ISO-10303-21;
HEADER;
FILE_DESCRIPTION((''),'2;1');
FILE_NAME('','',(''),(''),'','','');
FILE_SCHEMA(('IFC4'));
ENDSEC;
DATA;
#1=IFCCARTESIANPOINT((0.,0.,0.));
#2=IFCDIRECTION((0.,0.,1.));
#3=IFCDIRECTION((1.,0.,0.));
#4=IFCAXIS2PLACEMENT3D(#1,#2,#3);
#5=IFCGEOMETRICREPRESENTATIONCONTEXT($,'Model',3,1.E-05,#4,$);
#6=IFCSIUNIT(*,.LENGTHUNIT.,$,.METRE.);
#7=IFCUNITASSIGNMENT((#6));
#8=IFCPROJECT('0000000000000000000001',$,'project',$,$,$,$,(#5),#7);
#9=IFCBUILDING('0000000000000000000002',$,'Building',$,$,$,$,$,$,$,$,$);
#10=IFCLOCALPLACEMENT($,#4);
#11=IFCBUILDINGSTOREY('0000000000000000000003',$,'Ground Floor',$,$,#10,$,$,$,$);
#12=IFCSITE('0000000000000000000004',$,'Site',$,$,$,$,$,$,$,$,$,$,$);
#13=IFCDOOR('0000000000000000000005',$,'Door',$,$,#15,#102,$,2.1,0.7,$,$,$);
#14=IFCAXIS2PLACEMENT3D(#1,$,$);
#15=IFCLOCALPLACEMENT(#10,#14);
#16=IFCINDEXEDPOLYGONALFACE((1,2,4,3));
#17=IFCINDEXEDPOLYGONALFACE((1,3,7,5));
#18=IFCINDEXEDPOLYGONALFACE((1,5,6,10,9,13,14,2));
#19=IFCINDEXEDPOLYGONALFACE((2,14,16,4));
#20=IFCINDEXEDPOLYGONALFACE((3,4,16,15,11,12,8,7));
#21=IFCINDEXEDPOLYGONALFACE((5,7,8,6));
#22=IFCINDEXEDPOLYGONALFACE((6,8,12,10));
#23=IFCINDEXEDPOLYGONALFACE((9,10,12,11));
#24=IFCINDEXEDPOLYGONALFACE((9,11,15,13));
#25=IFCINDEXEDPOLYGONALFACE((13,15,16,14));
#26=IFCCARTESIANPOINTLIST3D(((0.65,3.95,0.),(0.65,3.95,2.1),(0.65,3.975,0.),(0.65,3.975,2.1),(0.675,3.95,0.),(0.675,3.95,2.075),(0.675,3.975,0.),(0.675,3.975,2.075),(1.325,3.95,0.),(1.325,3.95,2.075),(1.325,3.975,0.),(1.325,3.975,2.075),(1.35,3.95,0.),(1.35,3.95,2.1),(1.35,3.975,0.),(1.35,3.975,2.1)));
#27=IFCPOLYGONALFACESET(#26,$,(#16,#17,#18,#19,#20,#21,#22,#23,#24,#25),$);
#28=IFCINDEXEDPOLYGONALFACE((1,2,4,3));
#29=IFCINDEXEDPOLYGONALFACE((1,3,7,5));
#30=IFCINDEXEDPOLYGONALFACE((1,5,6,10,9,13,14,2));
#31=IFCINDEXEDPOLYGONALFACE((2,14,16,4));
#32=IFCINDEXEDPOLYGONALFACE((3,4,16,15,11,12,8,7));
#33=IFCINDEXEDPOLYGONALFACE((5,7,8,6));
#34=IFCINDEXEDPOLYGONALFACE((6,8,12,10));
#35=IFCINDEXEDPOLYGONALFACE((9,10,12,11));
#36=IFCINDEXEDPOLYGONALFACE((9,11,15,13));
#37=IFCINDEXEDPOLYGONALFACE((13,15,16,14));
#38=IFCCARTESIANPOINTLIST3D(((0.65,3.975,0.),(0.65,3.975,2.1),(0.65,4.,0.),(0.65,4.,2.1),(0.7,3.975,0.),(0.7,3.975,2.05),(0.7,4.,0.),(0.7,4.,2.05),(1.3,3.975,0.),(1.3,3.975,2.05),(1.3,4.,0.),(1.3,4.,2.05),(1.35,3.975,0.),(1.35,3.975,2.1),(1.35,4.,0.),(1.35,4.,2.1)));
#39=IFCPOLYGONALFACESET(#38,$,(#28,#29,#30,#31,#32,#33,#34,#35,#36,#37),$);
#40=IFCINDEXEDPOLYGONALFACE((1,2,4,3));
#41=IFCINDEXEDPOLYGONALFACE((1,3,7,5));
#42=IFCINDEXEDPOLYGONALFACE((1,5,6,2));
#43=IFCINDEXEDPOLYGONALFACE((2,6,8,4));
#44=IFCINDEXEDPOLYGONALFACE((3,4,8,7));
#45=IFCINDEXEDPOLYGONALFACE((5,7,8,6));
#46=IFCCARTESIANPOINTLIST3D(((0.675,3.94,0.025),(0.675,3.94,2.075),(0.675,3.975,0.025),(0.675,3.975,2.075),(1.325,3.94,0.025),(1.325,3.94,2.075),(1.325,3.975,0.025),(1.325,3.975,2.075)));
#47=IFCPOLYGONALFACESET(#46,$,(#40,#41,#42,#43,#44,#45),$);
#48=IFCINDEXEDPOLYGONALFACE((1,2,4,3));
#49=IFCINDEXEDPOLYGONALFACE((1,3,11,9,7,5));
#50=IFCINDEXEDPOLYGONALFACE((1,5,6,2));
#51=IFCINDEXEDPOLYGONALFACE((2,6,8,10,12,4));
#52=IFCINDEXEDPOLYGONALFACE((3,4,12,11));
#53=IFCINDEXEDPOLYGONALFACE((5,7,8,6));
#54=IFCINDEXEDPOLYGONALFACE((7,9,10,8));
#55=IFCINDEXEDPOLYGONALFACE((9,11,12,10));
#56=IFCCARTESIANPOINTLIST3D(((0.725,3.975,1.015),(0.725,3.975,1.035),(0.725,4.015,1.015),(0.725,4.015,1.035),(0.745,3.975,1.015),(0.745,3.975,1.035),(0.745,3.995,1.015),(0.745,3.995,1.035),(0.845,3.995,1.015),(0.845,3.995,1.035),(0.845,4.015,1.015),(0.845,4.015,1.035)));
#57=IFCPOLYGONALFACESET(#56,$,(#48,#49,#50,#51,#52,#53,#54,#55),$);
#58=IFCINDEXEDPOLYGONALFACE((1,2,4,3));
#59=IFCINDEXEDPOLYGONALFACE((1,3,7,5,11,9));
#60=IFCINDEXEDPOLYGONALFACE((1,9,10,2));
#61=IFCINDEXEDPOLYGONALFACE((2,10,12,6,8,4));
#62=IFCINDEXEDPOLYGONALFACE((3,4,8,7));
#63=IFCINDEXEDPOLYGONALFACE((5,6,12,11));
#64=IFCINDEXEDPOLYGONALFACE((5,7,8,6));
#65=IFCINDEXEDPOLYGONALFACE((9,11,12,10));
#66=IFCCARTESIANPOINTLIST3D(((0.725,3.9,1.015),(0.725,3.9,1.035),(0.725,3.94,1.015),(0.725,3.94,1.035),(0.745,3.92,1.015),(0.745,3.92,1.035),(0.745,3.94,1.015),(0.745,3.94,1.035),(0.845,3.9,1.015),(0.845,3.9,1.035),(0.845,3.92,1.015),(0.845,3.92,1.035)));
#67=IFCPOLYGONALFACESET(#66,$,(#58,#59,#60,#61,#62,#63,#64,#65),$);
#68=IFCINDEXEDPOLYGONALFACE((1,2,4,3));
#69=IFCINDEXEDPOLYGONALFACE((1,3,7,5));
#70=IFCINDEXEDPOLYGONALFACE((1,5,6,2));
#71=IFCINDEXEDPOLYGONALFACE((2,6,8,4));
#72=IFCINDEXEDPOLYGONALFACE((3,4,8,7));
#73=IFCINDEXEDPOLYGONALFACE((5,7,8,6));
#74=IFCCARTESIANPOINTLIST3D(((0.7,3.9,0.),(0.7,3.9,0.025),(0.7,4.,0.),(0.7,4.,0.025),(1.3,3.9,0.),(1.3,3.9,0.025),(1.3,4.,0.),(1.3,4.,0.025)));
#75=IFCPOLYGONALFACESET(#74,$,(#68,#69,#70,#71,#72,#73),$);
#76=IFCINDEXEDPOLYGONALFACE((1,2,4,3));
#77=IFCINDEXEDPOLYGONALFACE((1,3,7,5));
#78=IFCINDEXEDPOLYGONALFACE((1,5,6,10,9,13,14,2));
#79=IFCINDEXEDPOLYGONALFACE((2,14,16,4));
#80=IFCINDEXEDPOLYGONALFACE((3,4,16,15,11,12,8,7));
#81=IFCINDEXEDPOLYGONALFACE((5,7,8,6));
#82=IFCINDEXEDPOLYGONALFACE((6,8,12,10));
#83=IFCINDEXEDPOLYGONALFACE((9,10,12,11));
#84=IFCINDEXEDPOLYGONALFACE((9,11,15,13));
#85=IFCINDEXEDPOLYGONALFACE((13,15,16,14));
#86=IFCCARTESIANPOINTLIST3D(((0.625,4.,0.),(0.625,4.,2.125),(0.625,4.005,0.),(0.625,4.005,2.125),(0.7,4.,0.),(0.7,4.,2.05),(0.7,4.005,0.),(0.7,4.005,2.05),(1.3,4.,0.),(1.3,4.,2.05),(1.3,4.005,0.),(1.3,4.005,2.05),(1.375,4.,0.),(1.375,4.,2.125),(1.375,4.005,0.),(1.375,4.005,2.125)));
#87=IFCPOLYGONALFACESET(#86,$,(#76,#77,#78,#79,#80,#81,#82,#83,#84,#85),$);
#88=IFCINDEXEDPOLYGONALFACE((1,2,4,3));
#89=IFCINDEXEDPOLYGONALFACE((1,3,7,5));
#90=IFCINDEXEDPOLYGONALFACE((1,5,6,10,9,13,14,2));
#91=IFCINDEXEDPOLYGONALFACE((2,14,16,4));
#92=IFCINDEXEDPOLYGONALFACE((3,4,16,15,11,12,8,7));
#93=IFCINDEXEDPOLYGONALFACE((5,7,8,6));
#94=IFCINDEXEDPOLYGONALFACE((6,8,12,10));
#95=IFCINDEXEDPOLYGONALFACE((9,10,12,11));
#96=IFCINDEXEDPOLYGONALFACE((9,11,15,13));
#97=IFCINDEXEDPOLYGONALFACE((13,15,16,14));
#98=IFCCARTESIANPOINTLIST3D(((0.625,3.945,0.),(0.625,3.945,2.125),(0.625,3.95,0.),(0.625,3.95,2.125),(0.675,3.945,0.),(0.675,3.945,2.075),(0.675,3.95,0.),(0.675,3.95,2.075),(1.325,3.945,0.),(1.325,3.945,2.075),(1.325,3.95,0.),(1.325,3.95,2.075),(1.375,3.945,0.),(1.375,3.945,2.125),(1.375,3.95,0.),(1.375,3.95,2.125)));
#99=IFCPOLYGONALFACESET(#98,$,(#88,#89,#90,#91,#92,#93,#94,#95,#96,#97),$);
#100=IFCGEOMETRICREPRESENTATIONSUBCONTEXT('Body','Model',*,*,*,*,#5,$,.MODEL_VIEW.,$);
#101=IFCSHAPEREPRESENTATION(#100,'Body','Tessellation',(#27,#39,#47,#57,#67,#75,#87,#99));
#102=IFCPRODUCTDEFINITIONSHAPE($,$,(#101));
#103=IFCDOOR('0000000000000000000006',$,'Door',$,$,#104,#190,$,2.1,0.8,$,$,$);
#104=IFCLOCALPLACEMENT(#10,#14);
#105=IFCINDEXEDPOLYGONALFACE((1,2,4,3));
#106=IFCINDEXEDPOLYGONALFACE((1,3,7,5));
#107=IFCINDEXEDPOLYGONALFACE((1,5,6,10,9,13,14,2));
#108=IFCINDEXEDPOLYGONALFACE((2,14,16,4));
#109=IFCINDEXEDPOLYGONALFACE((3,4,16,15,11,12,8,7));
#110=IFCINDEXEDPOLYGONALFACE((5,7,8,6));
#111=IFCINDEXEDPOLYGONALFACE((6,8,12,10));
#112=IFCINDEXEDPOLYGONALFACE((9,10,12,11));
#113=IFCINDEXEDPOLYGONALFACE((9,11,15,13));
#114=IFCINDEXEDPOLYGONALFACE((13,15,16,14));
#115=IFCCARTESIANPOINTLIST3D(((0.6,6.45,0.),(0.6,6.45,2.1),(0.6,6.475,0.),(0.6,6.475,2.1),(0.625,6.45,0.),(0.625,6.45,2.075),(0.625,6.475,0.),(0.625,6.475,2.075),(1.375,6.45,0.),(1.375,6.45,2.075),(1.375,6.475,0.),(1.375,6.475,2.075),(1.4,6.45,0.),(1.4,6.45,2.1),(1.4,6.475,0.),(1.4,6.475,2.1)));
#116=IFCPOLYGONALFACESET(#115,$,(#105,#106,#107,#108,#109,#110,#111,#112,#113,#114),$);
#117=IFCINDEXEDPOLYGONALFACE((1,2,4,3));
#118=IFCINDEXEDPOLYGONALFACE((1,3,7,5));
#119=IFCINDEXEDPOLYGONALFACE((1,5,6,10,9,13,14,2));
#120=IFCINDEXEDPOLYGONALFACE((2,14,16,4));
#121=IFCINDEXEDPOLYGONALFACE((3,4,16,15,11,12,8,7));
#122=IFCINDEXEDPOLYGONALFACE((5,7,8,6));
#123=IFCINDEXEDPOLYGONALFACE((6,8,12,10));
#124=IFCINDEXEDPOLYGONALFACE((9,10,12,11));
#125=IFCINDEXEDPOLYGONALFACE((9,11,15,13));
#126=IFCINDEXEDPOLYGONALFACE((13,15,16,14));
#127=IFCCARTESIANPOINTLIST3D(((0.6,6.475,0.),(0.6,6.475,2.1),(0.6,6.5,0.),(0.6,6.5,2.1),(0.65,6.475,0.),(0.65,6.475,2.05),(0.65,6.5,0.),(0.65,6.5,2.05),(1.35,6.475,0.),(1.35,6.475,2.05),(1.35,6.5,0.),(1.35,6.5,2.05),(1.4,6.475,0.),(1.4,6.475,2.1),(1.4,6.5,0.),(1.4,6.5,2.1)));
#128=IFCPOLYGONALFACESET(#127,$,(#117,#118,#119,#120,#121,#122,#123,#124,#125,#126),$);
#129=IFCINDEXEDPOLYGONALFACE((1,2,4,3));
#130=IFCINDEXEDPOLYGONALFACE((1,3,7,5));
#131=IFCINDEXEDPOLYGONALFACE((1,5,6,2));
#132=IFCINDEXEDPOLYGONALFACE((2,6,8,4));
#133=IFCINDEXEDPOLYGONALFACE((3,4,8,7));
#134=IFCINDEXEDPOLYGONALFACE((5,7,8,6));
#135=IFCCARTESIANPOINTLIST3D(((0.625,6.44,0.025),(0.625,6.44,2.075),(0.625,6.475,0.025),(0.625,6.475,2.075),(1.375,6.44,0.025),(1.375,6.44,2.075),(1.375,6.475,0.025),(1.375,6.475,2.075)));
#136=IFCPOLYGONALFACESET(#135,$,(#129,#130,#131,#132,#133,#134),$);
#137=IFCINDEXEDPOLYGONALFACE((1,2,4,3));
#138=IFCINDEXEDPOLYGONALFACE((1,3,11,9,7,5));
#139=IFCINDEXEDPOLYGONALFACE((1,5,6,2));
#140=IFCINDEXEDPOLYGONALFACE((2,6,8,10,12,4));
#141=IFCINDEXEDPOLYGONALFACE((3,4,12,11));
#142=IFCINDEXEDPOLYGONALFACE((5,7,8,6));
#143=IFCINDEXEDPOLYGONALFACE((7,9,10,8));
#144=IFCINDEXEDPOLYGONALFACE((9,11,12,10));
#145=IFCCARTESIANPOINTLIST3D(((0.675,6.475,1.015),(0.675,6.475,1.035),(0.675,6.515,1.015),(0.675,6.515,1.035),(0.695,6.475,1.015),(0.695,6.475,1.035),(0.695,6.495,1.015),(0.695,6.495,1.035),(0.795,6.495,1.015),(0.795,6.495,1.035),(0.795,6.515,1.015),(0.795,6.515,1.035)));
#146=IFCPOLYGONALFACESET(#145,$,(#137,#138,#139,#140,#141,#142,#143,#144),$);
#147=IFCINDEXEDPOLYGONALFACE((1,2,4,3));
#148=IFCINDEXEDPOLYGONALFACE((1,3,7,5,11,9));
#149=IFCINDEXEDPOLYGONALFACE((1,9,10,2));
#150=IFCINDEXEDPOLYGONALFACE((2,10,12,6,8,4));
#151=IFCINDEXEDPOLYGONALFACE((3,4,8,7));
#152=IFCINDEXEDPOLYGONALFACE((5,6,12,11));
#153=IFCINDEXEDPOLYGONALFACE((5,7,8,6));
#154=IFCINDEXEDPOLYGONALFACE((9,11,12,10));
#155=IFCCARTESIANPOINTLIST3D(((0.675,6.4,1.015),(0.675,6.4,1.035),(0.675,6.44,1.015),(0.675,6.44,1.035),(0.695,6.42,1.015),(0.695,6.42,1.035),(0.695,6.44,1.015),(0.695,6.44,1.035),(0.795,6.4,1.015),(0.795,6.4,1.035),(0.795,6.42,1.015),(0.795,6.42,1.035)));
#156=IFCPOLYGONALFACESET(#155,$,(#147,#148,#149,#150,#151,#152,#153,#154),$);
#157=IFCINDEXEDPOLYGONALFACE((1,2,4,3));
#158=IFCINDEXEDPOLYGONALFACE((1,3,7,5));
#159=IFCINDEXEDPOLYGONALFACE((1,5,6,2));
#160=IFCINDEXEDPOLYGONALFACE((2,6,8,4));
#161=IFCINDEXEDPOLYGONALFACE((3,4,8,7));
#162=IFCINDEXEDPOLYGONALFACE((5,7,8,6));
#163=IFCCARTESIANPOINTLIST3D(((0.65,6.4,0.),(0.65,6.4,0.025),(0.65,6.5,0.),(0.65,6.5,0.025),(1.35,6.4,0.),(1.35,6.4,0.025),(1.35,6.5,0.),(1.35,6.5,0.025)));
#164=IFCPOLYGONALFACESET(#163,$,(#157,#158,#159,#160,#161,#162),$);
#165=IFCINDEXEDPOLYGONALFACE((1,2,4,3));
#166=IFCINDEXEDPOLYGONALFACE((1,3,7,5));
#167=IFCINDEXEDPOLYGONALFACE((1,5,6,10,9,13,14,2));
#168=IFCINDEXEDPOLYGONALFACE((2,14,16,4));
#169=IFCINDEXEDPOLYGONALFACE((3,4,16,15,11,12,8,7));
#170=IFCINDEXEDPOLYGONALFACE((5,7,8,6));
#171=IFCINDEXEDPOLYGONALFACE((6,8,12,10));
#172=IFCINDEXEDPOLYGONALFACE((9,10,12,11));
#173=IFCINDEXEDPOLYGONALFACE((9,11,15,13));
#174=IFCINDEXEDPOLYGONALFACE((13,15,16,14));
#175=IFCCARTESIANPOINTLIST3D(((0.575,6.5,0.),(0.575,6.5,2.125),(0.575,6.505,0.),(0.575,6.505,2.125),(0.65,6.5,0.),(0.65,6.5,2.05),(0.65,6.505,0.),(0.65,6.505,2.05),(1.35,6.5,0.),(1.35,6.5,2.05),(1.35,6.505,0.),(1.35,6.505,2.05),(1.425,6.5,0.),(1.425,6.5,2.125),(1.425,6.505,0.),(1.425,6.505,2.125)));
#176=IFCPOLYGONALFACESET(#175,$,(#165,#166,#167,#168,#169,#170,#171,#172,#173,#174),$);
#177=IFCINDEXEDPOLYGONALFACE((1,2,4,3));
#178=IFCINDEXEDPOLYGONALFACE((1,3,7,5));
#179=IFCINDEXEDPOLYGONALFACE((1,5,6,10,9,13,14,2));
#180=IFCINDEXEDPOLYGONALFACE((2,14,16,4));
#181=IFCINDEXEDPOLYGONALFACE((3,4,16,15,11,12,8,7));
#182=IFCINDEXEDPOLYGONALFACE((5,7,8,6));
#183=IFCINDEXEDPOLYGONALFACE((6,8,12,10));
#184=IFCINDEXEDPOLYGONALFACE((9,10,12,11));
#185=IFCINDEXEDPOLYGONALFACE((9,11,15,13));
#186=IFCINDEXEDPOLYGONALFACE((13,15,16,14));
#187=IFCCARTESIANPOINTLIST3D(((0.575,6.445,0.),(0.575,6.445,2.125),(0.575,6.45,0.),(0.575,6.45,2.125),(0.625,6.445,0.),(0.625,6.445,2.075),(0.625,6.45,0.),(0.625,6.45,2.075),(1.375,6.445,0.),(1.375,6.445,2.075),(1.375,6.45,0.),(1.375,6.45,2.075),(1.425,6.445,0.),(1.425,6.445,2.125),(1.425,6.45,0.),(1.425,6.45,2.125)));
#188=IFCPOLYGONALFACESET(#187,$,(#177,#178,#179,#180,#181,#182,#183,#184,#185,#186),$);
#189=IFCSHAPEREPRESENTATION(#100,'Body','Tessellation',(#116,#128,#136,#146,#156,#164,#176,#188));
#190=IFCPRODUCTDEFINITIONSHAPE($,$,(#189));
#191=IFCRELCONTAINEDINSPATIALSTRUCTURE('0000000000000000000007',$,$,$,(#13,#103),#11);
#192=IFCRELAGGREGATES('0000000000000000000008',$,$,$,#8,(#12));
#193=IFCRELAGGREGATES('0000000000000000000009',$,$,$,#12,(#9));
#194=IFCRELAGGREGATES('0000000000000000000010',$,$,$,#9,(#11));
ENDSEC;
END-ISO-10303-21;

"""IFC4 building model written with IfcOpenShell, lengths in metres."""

from ifc_helpers import new_model, si_unit, frame, origin_with_axes, place, context, subcontext, project, spatial, line, indexed_curve, outline, extrude, element, save


model = new_model("IFC4")

# Units and contexts
model_context = context("Model", 3, precision=1e-05, world=origin_with_axes())
body_context = subcontext(model_context, "Body", "Model", "MODEL_VIEW")
ifc_project = project(units=[si_unit("LENGTHUNIT", "METRE")], contexts=[model_context])

# Site, building, storey
site = spatial("IfcSite", under=ifc_project, Name="Site")
building = spatial("IfcBuilding", under=site, Name="Building")
storey_placement = place(None, origin_with_axes())
storey = spatial("IfcBuildingStorey", under=building, at=storey_placement, Name="Ground Floor")

# Doors
door_1_placement = place(storey_placement, frame((1.35, 4.0, 0.0), z_axis=(0.0, 0.0, 1.0), x_axis=(-1.0, 0.0, 0.0)))
element("IfcDoor", 1, at=door_1_placement, inside=storey, Name="Door", OverallHeight=2.1, OverallWidth=0.7, context=body_context, shape_type="SweptSolid", body=[
    extrude(outline(indexed_curve([(0.0, 0.0), (0.0, 2.1), (0.7, 2.1), (0.7, 0.0), (0.675, 0.0), (0.675, 2.075), (0.025, 2.075), (0.025, 0.0)], segments=[line(1, 2, 3, 4, 5, 6, 7, 8, 1)])), frame((0.0, 0.025, 0.0), z_axis=(0.0, -1.0, 0.0), x_axis=(1.0, 0.0, 0.0)), (0.0, 0.0, -1.0), 0.025),
    extrude(outline(indexed_curve([(0.0, 0.0), (0.0, 2.1), (0.7, 2.1), (0.7, 0.0), (0.65, 0.0), (0.65, 2.05), (0.05, 2.05), (0.05, 0.0)], segments=[line(1, 2, 3, 4, 5, 6, 7, 8, 1)])), frame((0.0, 0.0, 0.0), z_axis=(0.0, -1.0, 0.0), x_axis=(1.0, 0.0, 0.0)), (0.0, 0.0, -1.0), 0.025),
    extrude(outline(indexed_curve([(0.0, 0.0), (0.65, 0.0), (0.65, 0.035), (0.0, 0.035)], segments=[line(1, 2, 3, 4, 1)])), frame((0.025, 0.025, 0.025), z_axis=(0.0, 0.0, 1.0), x_axis=(1.0, 0.0, 0.0)), (0.0, 0.0, 1.0), 2.05),
    extrude(outline(indexed_curve([(0.0, 0.0), (0.0, -0.04), (-0.12, -0.04), (-0.12, -0.02), (-0.02, -0.02), (-0.02, 0.0)], segments=[line(1, 2, 3, 4, 5, 6, 1)])), frame((0.625, 0.025, 1.015), z_axis=(0.0, 0.0, 1.0), x_axis=(1.0, 0.0, 0.0)), (0.0, 0.0, 1.0), 0.02),
    extrude(outline(indexed_curve([(0.0, 0.0), (0.0, 0.04), (-0.12, 0.04), (-0.12, 0.02), (-0.02, 0.02), (-0.02, 0.0)], segments=[line(1, 2, 3, 4, 5, 6, 1)])), frame((0.625, 0.06, 1.015), z_axis=(0.0, 0.0, 1.0), x_axis=(1.0, 0.0, 0.0)), (0.0, 0.0, 1.0), 0.02),
    extrude(outline(indexed_curve([(0.0, 0.0), (0.6, 0.0), (0.6, 0.1), (0.0, 0.1)], segments=[line(1, 2, 3, 4, 1)])), frame((0.05, 0.0, 0.0), z_axis=(0.0, 0.0, 1.0), x_axis=(1.0, 0.0, 0.0)), (0.0, 0.0, 1.0), 0.025),
    extrude(outline(indexed_curve([(0.0, 0.0), (0.0, 2.125), (0.75, 2.125), (0.75, 0.0), (0.675, 0.0), (0.675, 2.05), (0.075, 2.05), (0.075, 0.0)], segments=[line(1, 2, 3, 4, 5, 6, 7, 8, 1)])), frame((-0.025, -0.005, 0.0), z_axis=(0.0, -1.0, 0.0), x_axis=(1.0, 0.0, 0.0)), (0.0, 0.0, -1.0), 0.005),
    extrude(outline(indexed_curve([(0.0, 0.0), (0.0, 2.125), (0.75, 2.125), (0.75, 0.0), (0.7, 0.0), (0.7, 2.075), (0.05, 2.075), (0.05, 0.0)], segments=[line(1, 2, 3, 4, 5, 6, 7, 8, 1)])), frame((-0.025, 0.05, 0.0), z_axis=(0.0, -1.0, 0.0), x_axis=(1.0, 0.0, 0.0)), (0.0, 0.0, -1.0), 0.005),
])
door_2_placement = place(storey_placement, frame((1.4, 6.5, 0.0), z_axis=(0.0, 0.0, 1.0), x_axis=(-1.0, 0.0, 0.0)))
element("IfcDoor", 2, at=door_2_placement, inside=storey, Name="Door", OverallHeight=2.1, OverallWidth=0.8, context=body_context, shape_type="SweptSolid", body=[
    extrude(outline(indexed_curve([(0.0, 0.0), (0.0, 2.1), (0.8, 2.1), (0.8, 0.0), (0.775, 0.0), (0.775, 2.075), (0.025, 2.075), (0.025, 0.0)], segments=[line(1, 2, 3, 4, 5, 6, 7, 8, 1)])), frame((0.0, 0.025, 0.0), z_axis=(0.0, -1.0, 0.0), x_axis=(1.0, 0.0, 0.0)), (0.0, 0.0, -1.0), 0.025),
    extrude(outline(indexed_curve([(0.0, 0.0), (0.0, 2.1), (0.8, 2.1), (0.8, 0.0), (0.75, 0.0), (0.75, 2.05), (0.05, 2.05), (0.05, 0.0)], segments=[line(1, 2, 3, 4, 5, 6, 7, 8, 1)])), frame((0.0, 0.0, 0.0), z_axis=(0.0, -1.0, 0.0), x_axis=(1.0, 0.0, 0.0)), (0.0, 0.0, -1.0), 0.025),
    extrude(outline(indexed_curve([(0.0, 0.0), (0.75, 0.0), (0.75, 0.035), (0.0, 0.035)], segments=[line(1, 2, 3, 4, 1)])), frame((0.025, 0.025, 0.025), z_axis=(0.0, 0.0, 1.0), x_axis=(1.0, 0.0, 0.0)), (0.0, 0.0, 1.0), 2.05),
    extrude(outline(indexed_curve([(0.0, 0.0), (0.0, -0.04), (-0.12, -0.04), (-0.12, -0.02), (-0.02, -0.02), (-0.02, 0.0)], segments=[line(1, 2, 3, 4, 5, 6, 1)])), frame((0.725, 0.025, 1.015), z_axis=(0.0, 0.0, 1.0), x_axis=(1.0, 0.0, 0.0)), (0.0, 0.0, 1.0), 0.02),
    extrude(outline(indexed_curve([(0.0, 0.0), (0.0, 0.04), (-0.12, 0.04), (-0.12, 0.02), (-0.02, 0.02), (-0.02, 0.0)], segments=[line(1, 2, 3, 4, 5, 6, 1)])), frame((0.725, 0.06, 1.015), z_axis=(0.0, 0.0, 1.0), x_axis=(1.0, 0.0, 0.0)), (0.0, 0.0, 1.0), 0.02),
    extrude(outline(indexed_curve([(0.0, 0.0), (0.7, 0.0), (0.7, 0.1), (0.0, 0.1)], segments=[line(1, 2, 3, 4, 1)])), frame((0.05, 0.0, 0.0), z_axis=(0.0, 0.0, 1.0), x_axis=(1.0, 0.0, 0.0)), (0.0, 0.0, 1.0), 0.025),
    extrude(outline(indexed_curve([(0.0, 0.0), (0.0, 2.125), (0.85, 2.125), (0.85, 0.0), (0.775, 0.0), (0.775, 2.05), (0.075, 2.05), (0.075, 0.0)], segments=[line(1, 2, 3, 4, 5, 6, 7, 8, 1)])), frame((-0.025, -0.005, 0.0), z_axis=(0.0, -1.0, 0.0), x_axis=(1.0, 0.0, 0.0)), (0.0, 0.0, -1.0), 0.005),
    extrude(outline(indexed_curve([(0.0, 0.0), (0.0, 2.125), (0.85, 2.125), (0.85, 0.0), (0.8, 0.0), (0.8, 2.075), (0.05, 2.075), (0.05, 0.0)], segments=[line(1, 2, 3, 4, 5, 6, 7, 8, 1)])), frame((-0.025, 0.05, 0.0), z_axis=(0.0, -1.0, 0.0), x_axis=(1.0, 0.0, 0.0)), (0.0, 0.0, -1.0), 0.005),
])

save(model, "model.ifc")
